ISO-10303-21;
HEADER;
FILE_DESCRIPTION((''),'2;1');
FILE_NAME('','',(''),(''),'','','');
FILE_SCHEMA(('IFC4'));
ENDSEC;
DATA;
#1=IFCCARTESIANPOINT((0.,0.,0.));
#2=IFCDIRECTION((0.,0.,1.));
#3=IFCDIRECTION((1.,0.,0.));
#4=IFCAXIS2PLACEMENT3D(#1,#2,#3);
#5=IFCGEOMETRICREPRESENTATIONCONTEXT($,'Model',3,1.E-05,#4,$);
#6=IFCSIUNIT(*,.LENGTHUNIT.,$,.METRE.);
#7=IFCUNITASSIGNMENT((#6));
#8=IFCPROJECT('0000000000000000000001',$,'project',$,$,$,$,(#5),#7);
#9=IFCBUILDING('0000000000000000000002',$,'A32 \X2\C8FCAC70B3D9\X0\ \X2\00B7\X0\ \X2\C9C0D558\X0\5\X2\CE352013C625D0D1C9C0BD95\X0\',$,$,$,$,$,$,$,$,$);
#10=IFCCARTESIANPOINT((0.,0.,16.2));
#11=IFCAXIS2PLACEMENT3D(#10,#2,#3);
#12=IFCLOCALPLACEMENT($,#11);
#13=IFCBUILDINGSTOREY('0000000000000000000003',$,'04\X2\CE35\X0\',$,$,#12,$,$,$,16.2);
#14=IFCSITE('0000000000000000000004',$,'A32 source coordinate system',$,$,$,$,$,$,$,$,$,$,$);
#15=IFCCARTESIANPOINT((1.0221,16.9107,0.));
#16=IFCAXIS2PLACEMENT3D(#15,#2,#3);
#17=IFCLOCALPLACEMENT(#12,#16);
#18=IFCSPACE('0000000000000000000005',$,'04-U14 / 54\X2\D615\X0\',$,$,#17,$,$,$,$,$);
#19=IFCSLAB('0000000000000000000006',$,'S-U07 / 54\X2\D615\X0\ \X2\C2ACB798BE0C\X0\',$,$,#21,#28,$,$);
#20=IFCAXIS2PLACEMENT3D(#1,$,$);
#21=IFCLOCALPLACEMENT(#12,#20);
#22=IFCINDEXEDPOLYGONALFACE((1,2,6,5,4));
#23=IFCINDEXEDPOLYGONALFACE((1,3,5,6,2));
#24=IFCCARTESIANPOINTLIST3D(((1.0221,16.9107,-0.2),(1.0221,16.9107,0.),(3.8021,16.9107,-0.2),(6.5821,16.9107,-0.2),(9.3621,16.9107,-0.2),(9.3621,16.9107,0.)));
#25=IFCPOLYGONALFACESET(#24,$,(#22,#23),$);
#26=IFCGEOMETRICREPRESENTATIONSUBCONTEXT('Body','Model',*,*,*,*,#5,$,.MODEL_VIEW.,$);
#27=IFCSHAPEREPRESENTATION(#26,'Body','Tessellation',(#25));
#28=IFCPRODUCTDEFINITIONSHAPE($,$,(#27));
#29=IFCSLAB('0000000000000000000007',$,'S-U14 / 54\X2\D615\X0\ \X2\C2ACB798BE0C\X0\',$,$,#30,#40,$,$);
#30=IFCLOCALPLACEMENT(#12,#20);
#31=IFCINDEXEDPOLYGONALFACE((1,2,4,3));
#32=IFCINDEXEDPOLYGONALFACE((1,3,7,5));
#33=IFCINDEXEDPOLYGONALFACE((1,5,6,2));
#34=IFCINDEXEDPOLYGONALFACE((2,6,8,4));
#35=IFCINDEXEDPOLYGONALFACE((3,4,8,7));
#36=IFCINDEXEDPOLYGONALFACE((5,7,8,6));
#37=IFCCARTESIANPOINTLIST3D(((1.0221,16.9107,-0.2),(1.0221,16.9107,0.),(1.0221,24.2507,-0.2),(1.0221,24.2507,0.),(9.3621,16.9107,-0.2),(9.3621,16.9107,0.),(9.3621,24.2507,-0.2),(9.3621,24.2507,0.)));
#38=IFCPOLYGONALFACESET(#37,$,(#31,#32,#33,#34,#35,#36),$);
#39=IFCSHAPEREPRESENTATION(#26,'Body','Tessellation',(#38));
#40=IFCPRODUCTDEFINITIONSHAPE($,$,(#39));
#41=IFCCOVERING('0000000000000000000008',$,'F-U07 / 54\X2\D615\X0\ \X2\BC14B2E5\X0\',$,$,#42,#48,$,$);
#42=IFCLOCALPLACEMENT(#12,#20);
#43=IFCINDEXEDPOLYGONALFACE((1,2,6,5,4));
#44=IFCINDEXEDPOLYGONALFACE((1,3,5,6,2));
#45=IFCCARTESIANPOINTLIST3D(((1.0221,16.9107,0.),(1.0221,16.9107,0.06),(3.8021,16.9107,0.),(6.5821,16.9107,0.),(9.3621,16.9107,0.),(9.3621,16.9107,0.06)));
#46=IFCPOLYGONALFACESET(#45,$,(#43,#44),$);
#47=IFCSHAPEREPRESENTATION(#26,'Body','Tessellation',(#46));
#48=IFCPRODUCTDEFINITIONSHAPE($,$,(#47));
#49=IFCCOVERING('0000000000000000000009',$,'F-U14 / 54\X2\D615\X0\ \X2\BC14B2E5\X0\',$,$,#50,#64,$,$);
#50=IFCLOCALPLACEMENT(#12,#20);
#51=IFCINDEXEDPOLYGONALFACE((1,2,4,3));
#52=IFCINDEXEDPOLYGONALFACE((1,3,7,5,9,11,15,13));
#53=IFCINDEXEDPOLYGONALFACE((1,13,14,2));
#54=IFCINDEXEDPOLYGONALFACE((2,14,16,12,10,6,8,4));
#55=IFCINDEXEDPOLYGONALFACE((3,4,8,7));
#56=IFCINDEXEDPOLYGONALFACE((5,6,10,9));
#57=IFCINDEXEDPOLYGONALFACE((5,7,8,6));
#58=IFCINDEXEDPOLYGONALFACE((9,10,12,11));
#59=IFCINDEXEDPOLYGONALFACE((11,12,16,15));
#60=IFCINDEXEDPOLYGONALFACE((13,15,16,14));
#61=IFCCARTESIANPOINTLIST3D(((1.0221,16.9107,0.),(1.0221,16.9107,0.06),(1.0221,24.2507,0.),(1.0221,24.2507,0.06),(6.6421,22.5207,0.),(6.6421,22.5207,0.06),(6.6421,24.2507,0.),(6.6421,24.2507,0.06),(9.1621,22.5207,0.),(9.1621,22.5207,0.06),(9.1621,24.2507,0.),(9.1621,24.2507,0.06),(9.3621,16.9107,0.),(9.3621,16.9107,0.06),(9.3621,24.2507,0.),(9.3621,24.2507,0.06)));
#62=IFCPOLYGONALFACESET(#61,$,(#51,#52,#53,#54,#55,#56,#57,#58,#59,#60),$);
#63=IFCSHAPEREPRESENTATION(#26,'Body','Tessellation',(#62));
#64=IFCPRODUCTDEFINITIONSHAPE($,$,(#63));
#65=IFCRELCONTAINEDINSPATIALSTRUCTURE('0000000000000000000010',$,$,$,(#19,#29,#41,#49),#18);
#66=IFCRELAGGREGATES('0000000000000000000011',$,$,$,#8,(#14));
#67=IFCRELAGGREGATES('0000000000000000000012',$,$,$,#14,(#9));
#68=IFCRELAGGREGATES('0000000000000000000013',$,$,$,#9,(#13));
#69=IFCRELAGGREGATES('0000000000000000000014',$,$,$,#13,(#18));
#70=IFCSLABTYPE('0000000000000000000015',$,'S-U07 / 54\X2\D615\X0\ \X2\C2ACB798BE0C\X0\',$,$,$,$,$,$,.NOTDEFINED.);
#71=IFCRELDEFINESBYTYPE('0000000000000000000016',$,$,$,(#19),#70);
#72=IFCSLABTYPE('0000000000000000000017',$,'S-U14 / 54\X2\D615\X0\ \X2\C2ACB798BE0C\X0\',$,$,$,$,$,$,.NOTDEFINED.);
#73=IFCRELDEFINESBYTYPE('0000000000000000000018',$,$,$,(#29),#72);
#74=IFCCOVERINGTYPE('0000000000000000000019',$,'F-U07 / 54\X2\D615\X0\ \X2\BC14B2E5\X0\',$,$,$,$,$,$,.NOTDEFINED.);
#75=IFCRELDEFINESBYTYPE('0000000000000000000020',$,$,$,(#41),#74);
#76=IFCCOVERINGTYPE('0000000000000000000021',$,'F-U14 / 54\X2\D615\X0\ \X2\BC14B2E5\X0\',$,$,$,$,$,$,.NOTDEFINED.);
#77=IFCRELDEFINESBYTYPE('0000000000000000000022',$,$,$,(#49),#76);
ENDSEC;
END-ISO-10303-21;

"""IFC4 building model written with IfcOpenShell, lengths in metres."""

from ifc_helpers import new_model, si_unit, frame, origin, origin_with_axes, place, context, subcontext, project, spatial, polyline, outline, extrude, source, transform, mapped, type_object, type_shapes, element, save


model = new_model("IFC4")

# Units and contexts
model_context = context("Model", 3, precision=1e-05, world=origin_with_axes())
body_context = subcontext(model_context, "Body", "Model", "MODEL_VIEW")
ifc_project = project(units=[si_unit("LENGTHUNIT", "METRE")], contexts=[model_context])

# Site, building, storey, space
storey_placement = place(None, frame((0.0, 0.0, 16.2), z_axis=(0.0, 0.0, 1.0), x_axis=(1.0, 0.0, 0.0)))
space_1_placement = place(storey_placement, frame((1.0221, 16.9107, 0.0), z_axis=(0.0, 0.0, 1.0), x_axis=(1.0, 0.0, 0.0)))
site = spatial("IfcSite", under=ifc_project, Name="A32 source coordinate system")
building = spatial("IfcBuilding", under=site, Name="A32 주거동 · 지하5층–옥탑지붕")
storey = spatial("IfcBuildingStorey", under=building, at=storey_placement, Name="04층", Elevation=16.2)
space_1 = spatial("IfcSpace", under=storey, at=space_1_placement, Name="04-U14 / 54형")

# Slabs
slab_type_1 = type_object("IfcSlabType", Name="S-U07 / 54형 슬래브", PredefinedType="NOTDEFINED")
shared_shape_1 = source(origin(), body_context, "Body", "SweptSolid", [
    extrude(outline(polyline([(0.0, 0.0), (0.0, 0.0), (8.34, 0.0), (8.34, 0.0), (0.0, 0.0)])), frame((0.0, 0.0, -0.2)), (0.0, 0.0, 1.0), 0.2),
])
type_shapes(slab_type_1, [shared_shape_1])
slab_1_placement = place(space_1_placement, origin_with_axes())
element("IfcSlab", 1, at=slab_1_placement, inside=space_1, type_object=slab_type_1, Name="S-U07 / 54형 슬래브", context=body_context, shape_type="MappedRepresentation", body=[
    mapped(shared_shape_1, transform((0.0, 0.0, 0.0), scale=1.0)),
])
slab_type_2 = type_object("IfcSlabType", Name="S-U14 / 54형 슬래브", PredefinedType="NOTDEFINED")
shared_shape_2 = source(origin(), body_context, "Body", "SweptSolid", [
    extrude(outline(polyline([(0.0, 0.0), (0.0, 7.34), (8.34, 7.34), (8.34, 0.0), (0.0, 0.0)])), frame((0.0, 0.0, -0.2)), (0.0, 0.0, 1.0), 0.2),
])
type_shapes(slab_type_2, [shared_shape_2])
slab_2_placement = place(space_1_placement, origin_with_axes())
element("IfcSlab", 2, at=slab_2_placement, inside=space_1, type_object=slab_type_2, Name="S-U14 / 54형 슬래브", context=body_context, shape_type="MappedRepresentation", body=[
    mapped(shared_shape_2, transform((0.0, 0.0, 0.0), scale=1.0)),
])

# Coverings
covering_type_1 = type_object("IfcCoveringType", Name="F-U07 / 54형 바닥", PredefinedType="NOTDEFINED")
shared_shape_3 = source(origin(), body_context, "Body", "SweptSolid", [
    extrude(outline(polyline([(0.0, 0.0), (0.0, 0.0), (8.34, 0.0), (8.34, 0.0), (0.0, 0.0)])), origin(), (0.0, 0.0, 1.0), 0.06),
])
type_shapes(covering_type_1, [shared_shape_3])
covering_1_placement = place(space_1_placement, origin_with_axes())
element("IfcCovering", 3, at=covering_1_placement, inside=space_1, type_object=covering_type_1, Name="F-U07 / 54형 바닥", context=body_context, shape_type="MappedRepresentation", body=[
    mapped(shared_shape_3, transform((0.0, 0.0, 0.0), scale=1.0)),
])
covering_type_2 = type_object("IfcCoveringType", Name="F-U14 / 54형 바닥", PredefinedType="NOTDEFINED")
shared_shape_4 = source(origin(), body_context, "Body", "SweptSolid", [
    extrude(outline(polyline([(8.14, 7.34), (8.34, 7.34), (8.34, 0.0), (0.0, 0.0), (0.0, 7.34), (5.62, 7.34), (5.62, 5.61), (8.14, 5.61), (8.14, 7.34)])), origin(), (0.0, 0.0, 1.0), 0.06),
])
type_shapes(covering_type_2, [shared_shape_4])
covering_2_placement = place(space_1_placement, origin_with_axes())
element("IfcCovering", 4, at=covering_2_placement, inside=space_1, type_object=covering_type_2, Name="F-U14 / 54형 바닥", context=body_context, shape_type="MappedRepresentation", body=[
    mapped(shared_shape_4, transform((0.0, 0.0, 0.0), scale=1.0)),
])

save(model, "model.ifc")
